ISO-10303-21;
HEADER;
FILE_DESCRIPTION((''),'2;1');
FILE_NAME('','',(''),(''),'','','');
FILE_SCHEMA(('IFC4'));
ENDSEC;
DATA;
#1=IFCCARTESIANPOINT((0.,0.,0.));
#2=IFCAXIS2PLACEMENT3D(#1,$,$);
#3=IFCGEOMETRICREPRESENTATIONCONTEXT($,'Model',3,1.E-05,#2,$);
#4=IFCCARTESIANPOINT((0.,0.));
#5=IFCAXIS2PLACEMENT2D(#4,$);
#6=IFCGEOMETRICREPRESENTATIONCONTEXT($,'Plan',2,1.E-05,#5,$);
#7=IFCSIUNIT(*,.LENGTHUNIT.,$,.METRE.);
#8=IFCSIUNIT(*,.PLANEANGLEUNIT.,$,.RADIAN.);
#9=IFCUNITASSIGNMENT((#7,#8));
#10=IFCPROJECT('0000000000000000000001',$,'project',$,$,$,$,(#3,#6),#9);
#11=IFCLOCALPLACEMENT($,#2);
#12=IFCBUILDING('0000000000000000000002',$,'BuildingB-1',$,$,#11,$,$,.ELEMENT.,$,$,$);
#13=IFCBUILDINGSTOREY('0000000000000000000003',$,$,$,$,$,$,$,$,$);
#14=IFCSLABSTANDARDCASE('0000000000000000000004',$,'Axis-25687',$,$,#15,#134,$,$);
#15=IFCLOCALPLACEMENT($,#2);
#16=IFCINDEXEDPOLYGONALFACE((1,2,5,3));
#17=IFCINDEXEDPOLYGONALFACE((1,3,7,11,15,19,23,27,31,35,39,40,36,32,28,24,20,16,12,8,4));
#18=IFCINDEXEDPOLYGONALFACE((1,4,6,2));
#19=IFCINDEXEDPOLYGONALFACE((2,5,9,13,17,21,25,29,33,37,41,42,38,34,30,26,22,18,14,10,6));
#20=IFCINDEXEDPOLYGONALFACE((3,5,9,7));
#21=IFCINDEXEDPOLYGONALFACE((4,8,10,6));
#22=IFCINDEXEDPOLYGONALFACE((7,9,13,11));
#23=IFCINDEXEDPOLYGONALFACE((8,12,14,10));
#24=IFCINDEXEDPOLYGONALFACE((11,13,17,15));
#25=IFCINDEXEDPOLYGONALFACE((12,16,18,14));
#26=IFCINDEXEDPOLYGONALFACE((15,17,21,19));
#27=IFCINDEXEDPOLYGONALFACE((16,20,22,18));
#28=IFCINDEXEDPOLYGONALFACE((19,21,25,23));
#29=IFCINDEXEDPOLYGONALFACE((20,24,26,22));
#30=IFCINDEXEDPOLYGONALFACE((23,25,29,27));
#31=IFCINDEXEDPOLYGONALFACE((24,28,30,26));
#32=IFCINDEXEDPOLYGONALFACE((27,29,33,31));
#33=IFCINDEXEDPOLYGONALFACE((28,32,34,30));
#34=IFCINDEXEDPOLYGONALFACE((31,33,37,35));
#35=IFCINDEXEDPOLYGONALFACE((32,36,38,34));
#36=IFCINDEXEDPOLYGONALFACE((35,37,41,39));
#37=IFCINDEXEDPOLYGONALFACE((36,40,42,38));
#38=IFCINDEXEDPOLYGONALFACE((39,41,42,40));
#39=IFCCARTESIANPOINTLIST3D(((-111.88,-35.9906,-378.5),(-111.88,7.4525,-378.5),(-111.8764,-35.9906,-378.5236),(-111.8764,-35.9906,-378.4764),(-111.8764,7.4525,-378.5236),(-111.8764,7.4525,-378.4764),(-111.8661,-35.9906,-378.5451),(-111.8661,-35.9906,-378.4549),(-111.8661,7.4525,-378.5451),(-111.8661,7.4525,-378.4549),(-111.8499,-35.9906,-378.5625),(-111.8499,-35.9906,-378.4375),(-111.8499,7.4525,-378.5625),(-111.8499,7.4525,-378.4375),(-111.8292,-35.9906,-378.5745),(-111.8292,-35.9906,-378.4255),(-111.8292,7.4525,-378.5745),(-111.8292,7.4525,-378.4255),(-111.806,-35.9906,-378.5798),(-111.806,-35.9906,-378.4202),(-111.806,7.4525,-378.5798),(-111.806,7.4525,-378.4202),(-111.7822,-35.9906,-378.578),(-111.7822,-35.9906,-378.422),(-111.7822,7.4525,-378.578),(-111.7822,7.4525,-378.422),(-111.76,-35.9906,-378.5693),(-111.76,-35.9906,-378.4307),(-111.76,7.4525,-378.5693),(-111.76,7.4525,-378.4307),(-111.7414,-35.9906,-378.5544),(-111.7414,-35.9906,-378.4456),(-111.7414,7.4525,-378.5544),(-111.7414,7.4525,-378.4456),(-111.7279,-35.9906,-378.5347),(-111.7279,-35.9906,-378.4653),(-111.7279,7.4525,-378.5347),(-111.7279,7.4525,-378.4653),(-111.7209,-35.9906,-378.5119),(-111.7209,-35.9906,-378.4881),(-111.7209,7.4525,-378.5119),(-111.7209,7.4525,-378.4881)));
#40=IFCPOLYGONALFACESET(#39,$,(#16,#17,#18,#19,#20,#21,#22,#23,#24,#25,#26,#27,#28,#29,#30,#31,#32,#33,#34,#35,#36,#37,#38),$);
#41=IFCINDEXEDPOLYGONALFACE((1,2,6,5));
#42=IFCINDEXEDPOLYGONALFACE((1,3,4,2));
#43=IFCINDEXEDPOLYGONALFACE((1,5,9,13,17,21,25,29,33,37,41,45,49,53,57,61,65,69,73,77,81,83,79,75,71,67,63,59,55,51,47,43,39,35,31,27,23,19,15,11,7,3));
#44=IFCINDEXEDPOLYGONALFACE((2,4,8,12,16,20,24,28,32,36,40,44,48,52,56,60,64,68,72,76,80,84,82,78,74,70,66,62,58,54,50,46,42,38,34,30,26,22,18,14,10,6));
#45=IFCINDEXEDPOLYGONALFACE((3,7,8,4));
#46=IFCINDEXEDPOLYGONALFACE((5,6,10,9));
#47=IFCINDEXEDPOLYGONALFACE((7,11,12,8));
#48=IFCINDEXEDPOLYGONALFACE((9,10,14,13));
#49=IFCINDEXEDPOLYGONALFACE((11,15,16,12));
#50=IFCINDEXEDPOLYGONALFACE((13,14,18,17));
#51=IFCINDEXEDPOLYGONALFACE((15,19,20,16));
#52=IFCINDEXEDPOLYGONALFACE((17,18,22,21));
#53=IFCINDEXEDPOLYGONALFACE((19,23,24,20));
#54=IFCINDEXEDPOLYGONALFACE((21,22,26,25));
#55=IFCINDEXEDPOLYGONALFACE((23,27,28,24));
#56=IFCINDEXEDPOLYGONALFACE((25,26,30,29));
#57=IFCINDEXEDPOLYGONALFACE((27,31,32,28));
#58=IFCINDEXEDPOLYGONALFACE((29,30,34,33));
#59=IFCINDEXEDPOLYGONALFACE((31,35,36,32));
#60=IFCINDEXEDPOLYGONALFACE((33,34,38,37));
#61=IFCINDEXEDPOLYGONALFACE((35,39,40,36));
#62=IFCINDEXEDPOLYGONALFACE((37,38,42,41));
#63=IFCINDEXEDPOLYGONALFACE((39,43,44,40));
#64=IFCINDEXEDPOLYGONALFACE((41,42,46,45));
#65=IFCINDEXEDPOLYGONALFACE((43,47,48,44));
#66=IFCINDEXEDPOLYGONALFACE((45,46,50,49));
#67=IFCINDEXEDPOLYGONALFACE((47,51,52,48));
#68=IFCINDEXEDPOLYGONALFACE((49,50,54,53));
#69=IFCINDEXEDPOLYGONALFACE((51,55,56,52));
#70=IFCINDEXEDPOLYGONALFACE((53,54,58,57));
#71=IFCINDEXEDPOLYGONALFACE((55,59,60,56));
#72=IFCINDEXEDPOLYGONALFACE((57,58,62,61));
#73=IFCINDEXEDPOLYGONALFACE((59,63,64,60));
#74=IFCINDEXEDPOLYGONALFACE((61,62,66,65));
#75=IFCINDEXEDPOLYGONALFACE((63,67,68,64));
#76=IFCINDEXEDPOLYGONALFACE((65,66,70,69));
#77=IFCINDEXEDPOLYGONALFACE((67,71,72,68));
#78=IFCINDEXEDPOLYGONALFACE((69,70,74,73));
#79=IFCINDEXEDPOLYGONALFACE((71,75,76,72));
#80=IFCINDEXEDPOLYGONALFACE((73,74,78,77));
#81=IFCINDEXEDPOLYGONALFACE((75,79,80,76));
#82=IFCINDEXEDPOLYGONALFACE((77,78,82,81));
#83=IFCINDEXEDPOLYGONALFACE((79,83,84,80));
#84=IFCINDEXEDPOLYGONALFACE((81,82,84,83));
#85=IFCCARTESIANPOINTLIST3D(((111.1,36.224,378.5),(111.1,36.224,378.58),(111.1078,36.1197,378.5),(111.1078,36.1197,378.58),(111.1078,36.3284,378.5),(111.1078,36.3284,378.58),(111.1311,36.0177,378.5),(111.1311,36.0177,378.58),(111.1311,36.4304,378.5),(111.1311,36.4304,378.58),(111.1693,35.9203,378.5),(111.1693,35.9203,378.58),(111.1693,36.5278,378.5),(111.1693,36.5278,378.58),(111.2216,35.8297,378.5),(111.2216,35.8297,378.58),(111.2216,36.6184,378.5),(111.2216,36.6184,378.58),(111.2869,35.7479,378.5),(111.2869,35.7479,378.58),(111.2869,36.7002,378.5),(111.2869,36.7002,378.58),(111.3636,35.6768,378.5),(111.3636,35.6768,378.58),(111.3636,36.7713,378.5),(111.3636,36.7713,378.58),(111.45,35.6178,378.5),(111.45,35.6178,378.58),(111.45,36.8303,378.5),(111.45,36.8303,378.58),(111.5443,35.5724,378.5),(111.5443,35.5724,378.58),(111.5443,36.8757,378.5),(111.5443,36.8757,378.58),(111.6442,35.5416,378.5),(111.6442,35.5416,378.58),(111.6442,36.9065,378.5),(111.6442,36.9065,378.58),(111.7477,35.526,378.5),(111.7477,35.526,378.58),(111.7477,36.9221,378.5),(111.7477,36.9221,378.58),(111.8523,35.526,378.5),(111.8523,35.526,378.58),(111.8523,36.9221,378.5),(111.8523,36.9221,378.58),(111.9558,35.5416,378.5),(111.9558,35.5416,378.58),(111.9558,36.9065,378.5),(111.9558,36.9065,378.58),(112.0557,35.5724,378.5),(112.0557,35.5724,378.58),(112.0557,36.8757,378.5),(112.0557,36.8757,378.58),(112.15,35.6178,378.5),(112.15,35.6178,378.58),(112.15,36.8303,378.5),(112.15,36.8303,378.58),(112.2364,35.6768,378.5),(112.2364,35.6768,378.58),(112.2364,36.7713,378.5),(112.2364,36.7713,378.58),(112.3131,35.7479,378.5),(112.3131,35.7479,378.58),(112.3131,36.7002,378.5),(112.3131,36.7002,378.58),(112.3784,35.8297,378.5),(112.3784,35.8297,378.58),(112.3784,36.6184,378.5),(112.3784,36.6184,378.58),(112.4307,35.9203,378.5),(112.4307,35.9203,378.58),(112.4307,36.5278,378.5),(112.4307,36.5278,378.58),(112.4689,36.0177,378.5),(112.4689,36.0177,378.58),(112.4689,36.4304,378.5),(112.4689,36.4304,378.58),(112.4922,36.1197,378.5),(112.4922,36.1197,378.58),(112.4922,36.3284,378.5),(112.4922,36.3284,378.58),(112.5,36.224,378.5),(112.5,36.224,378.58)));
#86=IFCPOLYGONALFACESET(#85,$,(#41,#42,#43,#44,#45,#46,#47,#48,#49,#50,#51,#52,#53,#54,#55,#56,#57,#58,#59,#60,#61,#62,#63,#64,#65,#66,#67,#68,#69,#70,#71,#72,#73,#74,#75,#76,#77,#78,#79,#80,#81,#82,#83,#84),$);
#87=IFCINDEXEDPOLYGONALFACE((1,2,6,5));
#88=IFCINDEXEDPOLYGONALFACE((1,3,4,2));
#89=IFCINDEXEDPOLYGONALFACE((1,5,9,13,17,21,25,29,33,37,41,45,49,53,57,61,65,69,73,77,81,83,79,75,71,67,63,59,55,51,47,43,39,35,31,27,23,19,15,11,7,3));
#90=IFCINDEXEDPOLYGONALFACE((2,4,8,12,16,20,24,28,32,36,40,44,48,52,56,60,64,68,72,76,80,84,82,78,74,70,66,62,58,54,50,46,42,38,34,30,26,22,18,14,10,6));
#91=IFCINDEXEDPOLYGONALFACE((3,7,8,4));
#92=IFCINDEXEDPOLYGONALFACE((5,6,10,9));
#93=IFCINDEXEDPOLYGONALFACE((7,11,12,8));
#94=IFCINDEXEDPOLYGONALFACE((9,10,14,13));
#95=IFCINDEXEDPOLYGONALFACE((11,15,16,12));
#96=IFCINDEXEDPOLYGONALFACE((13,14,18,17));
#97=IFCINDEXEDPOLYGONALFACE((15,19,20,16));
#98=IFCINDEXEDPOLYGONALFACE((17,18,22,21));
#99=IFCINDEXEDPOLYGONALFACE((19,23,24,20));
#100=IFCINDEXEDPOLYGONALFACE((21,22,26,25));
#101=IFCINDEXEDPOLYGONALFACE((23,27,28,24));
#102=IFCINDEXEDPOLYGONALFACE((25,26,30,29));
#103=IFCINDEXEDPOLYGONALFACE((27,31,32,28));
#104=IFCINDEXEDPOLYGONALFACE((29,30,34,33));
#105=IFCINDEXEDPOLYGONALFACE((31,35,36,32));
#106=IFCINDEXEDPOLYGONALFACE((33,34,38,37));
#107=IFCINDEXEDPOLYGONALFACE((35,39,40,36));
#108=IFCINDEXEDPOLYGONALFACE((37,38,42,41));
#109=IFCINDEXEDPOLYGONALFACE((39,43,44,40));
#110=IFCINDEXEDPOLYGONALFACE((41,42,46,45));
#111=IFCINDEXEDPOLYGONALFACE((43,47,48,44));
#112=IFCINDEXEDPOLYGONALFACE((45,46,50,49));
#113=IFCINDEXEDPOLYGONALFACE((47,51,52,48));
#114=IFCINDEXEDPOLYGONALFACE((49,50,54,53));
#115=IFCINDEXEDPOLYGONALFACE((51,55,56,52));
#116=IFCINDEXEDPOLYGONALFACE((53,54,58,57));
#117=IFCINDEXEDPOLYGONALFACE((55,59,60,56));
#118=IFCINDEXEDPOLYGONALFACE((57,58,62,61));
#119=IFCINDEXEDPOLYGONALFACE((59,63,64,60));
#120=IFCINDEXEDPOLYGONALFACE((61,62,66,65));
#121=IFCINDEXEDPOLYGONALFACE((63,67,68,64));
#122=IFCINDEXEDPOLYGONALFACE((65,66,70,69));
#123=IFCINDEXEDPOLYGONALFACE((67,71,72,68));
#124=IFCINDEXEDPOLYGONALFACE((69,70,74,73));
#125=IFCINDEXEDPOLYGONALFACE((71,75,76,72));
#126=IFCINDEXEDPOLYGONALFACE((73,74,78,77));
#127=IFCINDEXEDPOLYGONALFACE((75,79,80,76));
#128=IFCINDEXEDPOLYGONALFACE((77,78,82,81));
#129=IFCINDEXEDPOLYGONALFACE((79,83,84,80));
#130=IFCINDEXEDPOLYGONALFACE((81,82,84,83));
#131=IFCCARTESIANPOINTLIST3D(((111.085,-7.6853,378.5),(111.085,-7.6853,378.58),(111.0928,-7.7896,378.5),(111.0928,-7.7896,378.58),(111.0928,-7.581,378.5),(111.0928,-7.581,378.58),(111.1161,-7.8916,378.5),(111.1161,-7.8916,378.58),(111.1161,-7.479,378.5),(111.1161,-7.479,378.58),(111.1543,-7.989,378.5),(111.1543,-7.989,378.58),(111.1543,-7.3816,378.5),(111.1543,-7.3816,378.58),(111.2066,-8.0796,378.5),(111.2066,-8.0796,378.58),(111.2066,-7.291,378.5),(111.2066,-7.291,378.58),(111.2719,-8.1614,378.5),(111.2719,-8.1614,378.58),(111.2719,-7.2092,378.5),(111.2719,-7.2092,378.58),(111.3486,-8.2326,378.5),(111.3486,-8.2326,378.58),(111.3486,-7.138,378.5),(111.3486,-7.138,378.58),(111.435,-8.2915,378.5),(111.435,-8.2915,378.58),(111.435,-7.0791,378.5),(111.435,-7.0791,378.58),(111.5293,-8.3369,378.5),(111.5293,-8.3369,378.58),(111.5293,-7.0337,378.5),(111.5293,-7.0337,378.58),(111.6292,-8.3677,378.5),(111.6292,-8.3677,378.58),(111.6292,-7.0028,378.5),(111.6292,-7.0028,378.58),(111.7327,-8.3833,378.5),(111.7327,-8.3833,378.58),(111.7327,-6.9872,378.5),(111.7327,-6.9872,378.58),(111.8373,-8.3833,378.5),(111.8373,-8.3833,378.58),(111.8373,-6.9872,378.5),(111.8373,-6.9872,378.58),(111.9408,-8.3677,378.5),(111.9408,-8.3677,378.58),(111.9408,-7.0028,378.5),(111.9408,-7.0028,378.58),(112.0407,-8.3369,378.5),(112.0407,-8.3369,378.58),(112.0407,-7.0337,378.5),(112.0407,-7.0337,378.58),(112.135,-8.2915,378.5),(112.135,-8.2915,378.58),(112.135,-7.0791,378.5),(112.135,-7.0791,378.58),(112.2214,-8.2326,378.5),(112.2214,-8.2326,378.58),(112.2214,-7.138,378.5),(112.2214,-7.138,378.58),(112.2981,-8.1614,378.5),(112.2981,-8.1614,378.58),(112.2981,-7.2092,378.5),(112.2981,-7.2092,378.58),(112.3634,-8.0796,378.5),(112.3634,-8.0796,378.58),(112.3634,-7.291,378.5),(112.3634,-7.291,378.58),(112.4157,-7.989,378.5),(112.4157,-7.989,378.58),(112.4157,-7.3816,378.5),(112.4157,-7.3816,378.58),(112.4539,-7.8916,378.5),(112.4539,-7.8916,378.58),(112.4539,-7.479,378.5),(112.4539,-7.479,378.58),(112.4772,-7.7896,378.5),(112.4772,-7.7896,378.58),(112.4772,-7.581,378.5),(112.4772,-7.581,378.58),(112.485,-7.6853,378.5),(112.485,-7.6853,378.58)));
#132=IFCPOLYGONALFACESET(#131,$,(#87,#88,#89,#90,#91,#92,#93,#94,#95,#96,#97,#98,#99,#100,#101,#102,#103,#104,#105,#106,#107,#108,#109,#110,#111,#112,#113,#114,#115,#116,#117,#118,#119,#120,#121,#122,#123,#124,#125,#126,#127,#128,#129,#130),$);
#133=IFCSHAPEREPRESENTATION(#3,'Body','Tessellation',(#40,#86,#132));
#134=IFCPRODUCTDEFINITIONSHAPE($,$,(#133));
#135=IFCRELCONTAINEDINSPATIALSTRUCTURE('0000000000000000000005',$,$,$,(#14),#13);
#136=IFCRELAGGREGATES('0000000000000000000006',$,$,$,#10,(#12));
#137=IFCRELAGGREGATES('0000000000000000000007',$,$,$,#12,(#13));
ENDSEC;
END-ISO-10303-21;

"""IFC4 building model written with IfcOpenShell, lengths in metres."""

from ifc_helpers import new_model, entity, si_unit, frame, origin, origin_2d, place, context, project, spatial, circle, extrude, element, save


model = new_model("IFC4")

# Units and contexts
model_context = context("Model", 3, precision=1e-05, world=origin())
plan_context = context("Plan", 2, precision=1e-05, world=origin_2d())
ifc_project = project(units=[si_unit("LENGTHUNIT", "METRE"), si_unit("PLANEANGLEUNIT", "RADIAN")], contexts=[model_context, plan_context])

# Building, storey
building_placement = place(None, origin())
building = spatial("IfcBuilding", under=ifc_project, at=building_placement, Name="BuildingB-1", CompositionType="ELEMENT")
storey = spatial("IfcBuildingStorey", under=building)

# Slab
element("IfcSlabStandardCase", 1, inside=storey, Name="Axis-25687", context=model_context, shape_type="AdvancedSweptSolid", body=[
    entity("IfcSurfaceCurveSweptAreaSolid", entity("IfcCircleProfileDef", "AREA", None, None, 0.08), None, entity("IfcPolyline", [entity("IfcCartesianPoint", [111.8, 35.9906, 378.5]), entity("IfcCartesianPoint", [111.8, -7.4525, 378.5])]), None, None, entity("IfcPlane", entity("IfcAxis2Placement3D", entity("IfcCartesianPoint", [111.8, 35.9906, 378.5]), entity("IfcDirection", [0.0, 0.0, 1.0]), entity("IfcDirection", [1.0, 0.0, 0.0])))),
    extrude(circle(Radius=0.7), frame((111.8, 36.224, 378.5)), (0.0, 0.0, 1.0), 0.08),
    extrude(circle(Radius=0.7), frame((111.785, -7.6853, 378.5)), (0.0, 0.0, 1.0), 0.08),
])

save(model, "model.ifc")
